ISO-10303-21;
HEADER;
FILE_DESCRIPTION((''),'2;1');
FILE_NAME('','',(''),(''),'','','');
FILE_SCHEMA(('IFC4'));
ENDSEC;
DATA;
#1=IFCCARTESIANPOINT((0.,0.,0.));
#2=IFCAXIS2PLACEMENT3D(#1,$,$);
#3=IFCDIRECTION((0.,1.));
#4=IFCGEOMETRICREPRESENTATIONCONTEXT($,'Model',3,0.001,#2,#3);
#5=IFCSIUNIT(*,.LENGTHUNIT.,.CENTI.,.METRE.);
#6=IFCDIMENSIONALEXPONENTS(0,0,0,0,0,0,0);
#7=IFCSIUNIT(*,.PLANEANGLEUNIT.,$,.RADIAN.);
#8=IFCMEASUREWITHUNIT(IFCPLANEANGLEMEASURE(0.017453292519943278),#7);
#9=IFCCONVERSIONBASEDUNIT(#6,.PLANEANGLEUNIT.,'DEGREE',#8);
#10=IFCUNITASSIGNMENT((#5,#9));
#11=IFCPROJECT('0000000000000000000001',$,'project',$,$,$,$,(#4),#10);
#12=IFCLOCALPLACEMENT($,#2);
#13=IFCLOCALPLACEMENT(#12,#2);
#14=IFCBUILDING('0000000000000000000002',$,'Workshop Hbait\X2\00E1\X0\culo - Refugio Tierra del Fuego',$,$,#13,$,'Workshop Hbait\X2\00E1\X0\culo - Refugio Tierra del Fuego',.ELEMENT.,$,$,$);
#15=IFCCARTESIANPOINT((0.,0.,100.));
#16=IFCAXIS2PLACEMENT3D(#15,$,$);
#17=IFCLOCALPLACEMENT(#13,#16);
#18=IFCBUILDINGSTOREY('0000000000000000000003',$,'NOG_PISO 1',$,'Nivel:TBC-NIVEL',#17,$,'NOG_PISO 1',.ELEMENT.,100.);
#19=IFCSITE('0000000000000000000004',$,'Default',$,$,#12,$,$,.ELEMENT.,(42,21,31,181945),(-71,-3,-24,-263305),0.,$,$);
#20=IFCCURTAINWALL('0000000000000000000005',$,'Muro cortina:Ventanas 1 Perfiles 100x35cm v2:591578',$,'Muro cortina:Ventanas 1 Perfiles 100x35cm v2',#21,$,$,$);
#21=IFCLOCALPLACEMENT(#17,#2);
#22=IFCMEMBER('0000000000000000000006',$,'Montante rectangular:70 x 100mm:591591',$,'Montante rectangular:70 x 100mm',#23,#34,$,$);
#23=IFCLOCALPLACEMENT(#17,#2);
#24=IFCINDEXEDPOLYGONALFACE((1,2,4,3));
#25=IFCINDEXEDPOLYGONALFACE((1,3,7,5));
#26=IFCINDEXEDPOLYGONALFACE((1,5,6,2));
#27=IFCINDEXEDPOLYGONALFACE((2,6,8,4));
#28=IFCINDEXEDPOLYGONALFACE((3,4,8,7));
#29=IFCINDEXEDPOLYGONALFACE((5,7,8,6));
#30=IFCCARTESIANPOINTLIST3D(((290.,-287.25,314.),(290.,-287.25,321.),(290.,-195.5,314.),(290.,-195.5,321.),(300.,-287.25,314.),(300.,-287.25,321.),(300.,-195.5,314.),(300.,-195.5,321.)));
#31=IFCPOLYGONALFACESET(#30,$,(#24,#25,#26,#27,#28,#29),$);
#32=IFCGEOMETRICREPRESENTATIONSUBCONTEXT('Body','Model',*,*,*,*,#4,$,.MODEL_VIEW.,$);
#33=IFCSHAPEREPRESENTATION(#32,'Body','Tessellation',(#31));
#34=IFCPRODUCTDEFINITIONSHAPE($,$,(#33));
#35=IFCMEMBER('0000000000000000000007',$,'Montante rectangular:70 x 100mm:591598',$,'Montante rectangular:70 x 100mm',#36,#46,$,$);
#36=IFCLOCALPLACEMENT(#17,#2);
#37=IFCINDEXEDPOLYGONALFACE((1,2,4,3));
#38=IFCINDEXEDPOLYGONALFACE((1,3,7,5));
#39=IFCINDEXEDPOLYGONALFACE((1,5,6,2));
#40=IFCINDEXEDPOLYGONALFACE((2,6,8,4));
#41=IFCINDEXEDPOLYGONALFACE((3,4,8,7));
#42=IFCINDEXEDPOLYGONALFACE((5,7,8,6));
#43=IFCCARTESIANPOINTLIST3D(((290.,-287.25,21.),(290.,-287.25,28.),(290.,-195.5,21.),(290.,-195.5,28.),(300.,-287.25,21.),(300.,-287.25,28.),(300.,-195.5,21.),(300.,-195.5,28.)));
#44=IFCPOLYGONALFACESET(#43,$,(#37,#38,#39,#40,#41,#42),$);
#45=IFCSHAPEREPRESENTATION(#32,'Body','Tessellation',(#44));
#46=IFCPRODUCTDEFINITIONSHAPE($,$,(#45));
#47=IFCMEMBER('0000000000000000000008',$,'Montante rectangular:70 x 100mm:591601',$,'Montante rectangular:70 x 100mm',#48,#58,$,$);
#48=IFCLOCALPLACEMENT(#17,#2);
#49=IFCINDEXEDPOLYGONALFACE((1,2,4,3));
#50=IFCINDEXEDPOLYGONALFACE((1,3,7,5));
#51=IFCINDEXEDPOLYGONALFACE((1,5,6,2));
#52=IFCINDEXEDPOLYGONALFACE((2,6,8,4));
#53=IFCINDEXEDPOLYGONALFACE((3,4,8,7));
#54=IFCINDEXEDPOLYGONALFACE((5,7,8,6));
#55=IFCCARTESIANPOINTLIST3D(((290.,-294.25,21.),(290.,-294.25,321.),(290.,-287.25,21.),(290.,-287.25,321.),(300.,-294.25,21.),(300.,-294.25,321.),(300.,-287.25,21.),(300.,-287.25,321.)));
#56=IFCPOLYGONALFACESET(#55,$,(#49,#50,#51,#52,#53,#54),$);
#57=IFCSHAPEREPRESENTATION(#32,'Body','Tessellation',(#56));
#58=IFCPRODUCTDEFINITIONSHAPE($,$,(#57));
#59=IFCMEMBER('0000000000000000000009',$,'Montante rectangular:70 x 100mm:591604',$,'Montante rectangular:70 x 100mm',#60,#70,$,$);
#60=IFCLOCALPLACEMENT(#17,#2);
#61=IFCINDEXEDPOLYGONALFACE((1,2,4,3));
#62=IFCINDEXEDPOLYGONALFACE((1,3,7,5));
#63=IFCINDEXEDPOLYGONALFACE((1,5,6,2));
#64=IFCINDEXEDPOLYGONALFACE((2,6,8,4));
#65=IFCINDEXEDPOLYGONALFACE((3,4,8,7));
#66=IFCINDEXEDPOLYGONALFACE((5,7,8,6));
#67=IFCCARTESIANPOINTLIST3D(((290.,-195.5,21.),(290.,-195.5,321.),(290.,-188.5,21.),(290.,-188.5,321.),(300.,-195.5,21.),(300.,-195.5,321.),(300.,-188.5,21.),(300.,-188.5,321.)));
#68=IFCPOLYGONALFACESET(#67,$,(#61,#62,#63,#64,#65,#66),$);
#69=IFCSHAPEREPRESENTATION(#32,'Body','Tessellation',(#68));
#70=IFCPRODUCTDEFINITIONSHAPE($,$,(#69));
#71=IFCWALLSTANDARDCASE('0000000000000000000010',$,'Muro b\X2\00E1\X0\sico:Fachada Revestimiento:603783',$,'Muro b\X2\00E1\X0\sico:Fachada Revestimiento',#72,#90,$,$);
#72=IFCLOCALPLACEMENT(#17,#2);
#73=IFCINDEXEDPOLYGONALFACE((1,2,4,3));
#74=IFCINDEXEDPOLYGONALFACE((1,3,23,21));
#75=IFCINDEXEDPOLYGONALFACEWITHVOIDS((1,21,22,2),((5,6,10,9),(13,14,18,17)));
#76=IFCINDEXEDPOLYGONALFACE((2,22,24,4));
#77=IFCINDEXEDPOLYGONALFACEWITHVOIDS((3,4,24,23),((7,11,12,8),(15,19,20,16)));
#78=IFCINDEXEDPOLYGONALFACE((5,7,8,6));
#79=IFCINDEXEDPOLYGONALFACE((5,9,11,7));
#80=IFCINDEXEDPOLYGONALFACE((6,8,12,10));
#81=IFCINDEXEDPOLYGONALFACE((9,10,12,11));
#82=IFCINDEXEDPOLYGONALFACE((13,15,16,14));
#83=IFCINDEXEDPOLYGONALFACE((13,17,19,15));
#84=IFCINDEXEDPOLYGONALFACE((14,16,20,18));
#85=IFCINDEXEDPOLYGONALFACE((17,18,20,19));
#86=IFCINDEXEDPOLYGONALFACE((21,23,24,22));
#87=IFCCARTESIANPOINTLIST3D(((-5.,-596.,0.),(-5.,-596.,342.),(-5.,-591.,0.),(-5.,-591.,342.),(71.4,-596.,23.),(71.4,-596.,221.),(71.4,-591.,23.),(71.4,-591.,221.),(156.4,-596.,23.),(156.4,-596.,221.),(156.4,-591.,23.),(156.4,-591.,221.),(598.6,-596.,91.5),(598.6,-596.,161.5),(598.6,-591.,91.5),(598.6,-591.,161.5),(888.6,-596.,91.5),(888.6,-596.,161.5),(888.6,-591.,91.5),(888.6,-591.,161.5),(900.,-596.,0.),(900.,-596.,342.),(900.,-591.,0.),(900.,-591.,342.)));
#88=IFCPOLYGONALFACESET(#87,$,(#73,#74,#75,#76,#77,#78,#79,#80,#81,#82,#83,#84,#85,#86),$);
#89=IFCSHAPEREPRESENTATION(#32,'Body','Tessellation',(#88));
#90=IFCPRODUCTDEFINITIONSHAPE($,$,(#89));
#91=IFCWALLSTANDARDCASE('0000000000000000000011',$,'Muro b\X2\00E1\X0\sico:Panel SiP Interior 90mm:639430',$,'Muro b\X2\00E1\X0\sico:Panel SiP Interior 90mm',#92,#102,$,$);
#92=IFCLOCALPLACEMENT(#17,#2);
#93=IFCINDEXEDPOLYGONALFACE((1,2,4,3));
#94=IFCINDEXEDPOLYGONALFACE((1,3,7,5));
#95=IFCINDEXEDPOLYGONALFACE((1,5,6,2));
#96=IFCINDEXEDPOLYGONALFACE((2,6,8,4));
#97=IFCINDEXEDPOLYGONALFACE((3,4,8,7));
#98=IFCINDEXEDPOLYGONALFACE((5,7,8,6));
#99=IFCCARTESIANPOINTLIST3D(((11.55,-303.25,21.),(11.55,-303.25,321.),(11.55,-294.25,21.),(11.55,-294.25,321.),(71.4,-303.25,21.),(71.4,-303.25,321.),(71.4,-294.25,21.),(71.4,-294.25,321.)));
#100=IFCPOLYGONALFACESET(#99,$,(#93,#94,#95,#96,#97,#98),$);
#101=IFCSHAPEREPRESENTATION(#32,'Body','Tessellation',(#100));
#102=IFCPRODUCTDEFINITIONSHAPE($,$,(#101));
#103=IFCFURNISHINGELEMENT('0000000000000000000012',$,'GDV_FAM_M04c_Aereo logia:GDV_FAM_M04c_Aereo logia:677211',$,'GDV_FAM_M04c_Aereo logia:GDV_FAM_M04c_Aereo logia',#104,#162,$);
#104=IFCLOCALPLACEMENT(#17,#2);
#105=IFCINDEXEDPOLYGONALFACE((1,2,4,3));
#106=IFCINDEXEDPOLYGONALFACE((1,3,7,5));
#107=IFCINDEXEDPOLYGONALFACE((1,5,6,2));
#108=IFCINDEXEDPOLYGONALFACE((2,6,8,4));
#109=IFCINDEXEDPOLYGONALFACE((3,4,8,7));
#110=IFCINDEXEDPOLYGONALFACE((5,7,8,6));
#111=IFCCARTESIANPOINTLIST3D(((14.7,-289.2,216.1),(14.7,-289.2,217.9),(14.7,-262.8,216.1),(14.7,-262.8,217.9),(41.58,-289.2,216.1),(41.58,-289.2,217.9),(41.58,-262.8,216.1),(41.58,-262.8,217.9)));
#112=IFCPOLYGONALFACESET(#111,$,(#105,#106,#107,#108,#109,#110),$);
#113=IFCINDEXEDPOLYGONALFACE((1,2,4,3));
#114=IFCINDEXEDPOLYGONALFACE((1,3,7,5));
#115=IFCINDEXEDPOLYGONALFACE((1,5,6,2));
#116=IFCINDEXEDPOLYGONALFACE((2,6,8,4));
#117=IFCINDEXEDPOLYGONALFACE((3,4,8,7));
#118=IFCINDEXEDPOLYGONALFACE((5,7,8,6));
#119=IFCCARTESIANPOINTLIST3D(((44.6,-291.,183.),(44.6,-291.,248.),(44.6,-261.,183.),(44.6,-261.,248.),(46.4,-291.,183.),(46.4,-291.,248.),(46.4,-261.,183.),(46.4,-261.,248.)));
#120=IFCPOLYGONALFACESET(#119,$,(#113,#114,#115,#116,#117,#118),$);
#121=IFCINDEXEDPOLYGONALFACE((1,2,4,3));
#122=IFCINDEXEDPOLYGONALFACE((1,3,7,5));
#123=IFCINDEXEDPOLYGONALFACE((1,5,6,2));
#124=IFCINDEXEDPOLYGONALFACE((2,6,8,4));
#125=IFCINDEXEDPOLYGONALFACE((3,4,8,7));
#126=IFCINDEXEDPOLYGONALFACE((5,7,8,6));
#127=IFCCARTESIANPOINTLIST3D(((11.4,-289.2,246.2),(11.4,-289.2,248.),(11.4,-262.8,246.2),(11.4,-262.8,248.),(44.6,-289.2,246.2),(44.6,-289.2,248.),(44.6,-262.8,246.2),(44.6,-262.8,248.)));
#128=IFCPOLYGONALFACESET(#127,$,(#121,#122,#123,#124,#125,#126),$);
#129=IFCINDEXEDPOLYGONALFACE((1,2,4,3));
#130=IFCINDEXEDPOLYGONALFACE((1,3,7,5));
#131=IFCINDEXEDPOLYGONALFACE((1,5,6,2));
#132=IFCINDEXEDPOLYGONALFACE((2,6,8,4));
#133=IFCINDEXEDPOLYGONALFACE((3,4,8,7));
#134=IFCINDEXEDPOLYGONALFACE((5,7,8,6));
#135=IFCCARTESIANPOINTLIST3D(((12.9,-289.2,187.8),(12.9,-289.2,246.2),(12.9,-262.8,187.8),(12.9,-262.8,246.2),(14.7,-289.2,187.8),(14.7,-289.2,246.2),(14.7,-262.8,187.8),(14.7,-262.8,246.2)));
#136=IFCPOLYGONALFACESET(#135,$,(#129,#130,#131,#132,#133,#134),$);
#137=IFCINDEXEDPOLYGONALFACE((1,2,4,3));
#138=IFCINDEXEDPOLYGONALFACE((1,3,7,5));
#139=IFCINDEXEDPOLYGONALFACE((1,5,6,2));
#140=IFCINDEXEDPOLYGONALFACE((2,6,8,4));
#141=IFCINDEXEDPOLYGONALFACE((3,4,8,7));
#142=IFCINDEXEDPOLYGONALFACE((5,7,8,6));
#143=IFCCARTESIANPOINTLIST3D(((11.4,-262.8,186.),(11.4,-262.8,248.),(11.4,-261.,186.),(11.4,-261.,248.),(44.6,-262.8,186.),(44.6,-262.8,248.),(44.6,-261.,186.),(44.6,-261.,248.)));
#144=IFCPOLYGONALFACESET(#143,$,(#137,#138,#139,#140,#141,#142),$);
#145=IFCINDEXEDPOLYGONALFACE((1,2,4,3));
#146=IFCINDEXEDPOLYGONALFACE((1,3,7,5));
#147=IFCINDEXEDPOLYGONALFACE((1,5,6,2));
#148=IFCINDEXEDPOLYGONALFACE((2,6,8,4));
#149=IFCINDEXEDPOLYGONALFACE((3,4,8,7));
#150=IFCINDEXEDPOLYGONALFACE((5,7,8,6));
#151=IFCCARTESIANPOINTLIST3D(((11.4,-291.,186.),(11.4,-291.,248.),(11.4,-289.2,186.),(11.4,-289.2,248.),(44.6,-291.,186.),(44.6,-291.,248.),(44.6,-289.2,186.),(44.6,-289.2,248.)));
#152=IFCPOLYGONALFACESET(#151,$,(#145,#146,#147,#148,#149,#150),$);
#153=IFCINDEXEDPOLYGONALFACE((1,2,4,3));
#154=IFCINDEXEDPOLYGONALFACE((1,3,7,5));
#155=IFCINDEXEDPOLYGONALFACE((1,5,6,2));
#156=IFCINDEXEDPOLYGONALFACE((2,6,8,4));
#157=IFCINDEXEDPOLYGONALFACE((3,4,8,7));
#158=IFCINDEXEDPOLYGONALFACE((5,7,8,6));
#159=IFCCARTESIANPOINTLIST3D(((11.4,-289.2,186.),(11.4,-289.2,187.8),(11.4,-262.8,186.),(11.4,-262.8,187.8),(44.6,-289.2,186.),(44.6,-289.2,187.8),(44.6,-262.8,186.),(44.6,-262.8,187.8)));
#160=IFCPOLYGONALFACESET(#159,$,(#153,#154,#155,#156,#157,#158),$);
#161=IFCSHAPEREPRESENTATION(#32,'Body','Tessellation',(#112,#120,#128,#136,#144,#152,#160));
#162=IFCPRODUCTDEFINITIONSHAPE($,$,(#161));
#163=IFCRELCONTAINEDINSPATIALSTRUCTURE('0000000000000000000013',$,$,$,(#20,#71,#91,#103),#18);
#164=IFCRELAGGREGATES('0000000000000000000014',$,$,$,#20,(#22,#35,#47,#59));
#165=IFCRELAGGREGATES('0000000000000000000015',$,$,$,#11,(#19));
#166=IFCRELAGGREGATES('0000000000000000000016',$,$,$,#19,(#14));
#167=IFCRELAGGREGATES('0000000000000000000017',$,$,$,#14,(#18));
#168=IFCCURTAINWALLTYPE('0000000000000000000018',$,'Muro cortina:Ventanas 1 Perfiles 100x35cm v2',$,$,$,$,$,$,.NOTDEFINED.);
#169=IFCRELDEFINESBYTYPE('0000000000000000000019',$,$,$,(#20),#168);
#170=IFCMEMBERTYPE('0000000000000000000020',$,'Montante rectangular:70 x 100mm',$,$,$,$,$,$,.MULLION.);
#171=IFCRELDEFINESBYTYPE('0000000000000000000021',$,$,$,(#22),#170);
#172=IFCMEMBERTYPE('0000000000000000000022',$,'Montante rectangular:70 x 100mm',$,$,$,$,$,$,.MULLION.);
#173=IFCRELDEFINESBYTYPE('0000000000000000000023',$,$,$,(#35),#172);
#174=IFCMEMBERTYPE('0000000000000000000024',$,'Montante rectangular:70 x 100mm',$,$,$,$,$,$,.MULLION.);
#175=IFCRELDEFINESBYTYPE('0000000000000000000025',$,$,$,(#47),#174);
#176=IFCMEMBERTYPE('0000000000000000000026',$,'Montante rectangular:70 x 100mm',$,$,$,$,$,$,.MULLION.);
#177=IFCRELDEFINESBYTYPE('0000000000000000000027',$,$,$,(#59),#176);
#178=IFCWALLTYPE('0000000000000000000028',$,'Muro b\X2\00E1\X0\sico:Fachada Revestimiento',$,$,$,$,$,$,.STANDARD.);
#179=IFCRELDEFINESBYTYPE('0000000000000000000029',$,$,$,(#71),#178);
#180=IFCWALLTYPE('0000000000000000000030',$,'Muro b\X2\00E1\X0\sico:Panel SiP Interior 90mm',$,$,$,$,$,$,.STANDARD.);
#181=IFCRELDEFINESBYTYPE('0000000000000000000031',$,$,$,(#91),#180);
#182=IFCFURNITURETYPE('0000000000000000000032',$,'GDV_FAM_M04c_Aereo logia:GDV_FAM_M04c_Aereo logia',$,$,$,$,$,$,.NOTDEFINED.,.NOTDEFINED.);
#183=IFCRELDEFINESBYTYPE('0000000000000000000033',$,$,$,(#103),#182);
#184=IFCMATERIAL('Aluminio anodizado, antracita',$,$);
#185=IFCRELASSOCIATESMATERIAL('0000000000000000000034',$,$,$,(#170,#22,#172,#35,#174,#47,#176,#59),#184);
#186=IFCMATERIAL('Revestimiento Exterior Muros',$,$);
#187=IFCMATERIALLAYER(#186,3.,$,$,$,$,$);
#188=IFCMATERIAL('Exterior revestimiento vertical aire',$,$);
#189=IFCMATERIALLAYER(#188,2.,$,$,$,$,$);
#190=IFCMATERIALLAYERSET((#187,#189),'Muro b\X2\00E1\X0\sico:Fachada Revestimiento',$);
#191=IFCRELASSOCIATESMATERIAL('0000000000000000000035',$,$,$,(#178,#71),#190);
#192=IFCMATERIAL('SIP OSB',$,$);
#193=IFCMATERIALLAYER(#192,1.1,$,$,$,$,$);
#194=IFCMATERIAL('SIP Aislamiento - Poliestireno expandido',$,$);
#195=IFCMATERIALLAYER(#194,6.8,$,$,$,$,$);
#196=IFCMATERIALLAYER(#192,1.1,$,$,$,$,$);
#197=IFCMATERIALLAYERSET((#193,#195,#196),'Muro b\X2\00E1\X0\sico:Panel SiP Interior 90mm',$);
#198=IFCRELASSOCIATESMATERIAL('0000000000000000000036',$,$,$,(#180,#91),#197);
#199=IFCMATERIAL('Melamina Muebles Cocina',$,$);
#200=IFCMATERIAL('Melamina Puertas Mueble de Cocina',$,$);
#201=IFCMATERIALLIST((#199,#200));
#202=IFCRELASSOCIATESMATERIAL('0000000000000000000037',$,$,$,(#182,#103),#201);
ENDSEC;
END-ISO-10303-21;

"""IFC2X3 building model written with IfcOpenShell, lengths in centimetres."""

from ifc_helpers import new_model, entity, si_unit, converted_unit, direction, frame, frame_2d, origin, origin_2d_with_axis, place, context, subcontext, project, spatial, rectangle, extrude, source, transform, mapped, material, material_list, layer, layer_set, layer_usage, type_object, type_shapes, element, aggregate, save


model = new_model("IFC2X3")

# Units and contexts
model_context = context("Model", 3, precision=0.001, world=origin(), true_north=direction((0.0, 1.0)))
body_context = subcontext(model_context, "Body", "Model", "MODEL_VIEW")
ifc_project = project(units=[si_unit("LENGTHUNIT", "METRE", prefix="CENTI"), converted_unit("PLANEANGLEUNIT", "DEGREE", entity("IfcPlaneAngleMeasure", 0.017453292519943278), si_unit("PLANEANGLEUNIT", "RADIAN"), dimensions=[0, 0, 0, 0, 0, 0, 0])], contexts=[model_context])

# Site, building, storey
site_placement = place(None, origin())
site = spatial("IfcSite", under=ifc_project, at=site_placement, Name="Default", CompositionType="ELEMENT", RefLatitude=(42, 21, 31, 181945), RefLongitude=(-71, -3, -24, -263305), RefElevation=0.0)
building_placement = place(site_placement, origin())
building = spatial("IfcBuilding", under=site, at=building_placement, Name="Workshop Hbaitáculo - Refugio Tierra del Fuego", LongName="Workshop Hbaitáculo - Refugio Tierra del Fuego", CompositionType="ELEMENT")
storey_placement = place(building_placement, frame((0.0, 0.0, 100.0)))
storey = spatial("IfcBuildingStorey", under=building, at=storey_placement, Name="NOG_PISO 1", ObjectType="Nivel:TBC-NIVEL", LongName="NOG_PISO 1", CompositionType="ELEMENT", Elevation=100.0)

# Curtain wall, members
curtain_wall_type = type_object("IfcCurtainWallType", Name="Muro cortina:Ventanas 1 Perfiles 100x35cm v2", PredefinedType="NOTDEFINED")
curtain_wall_placement = place(storey_placement, frame((0.0, 0.0, -100.0)))
curtain_wall = element("IfcCurtainWall", 1, at=curtain_wall_placement, inside=storey, type_object=curtain_wall_type, Name="Muro cortina:Ventanas 1 Perfiles 100x35cm v2:591578", ObjectType="Muro cortina:Ventanas 1 Perfiles 100x35cm v2")
ifc_material_1 = material(Name="Aluminio anodizado, antracita")
member_type_1 = type_object("IfcMemberType", Name="Montante rectangular:70 x 100mm", PredefinedType="MULLION", material=ifc_material_1)
shared_shape_1 = source(origin(), body_context, "Body", "SweptSolid", [
    extrude(rectangle(XDim=7.0, YDim=10.0, at=origin_2d_with_axis()), frame((-3.5, 0.0, -91.75), z_axis=(0.0, 0.0, 1.0), x_axis=(-1.0, 0.0, 0.0)), (0.0, 0.0, 1.0), 91.75),
])
type_shapes(member_type_1, [shared_shape_1])
member_1_placement = place(curtain_wall_placement, frame((295.0, -287.25, 421.0), z_axis=(0.0, -1.0, 0.0), x_axis=(0.0, 0.0, 1.0)))
member_1 = element("IfcMember", 2, at=member_1_placement, type_object=member_type_1, material=ifc_material_1, Name="Montante rectangular:70 x 100mm:591591", ObjectType="Montante rectangular:70 x 100mm", context=body_context, shape_type="MappedRepresentation", body=[
    mapped(shared_shape_1, transform((0.0, 0.0, 0.0), scale=1.0)),
])
member_type_2 = type_object("IfcMemberType", Name="Montante rectangular:70 x 100mm", PredefinedType="MULLION", material=ifc_material_1)
shared_shape_2 = source(origin(), body_context, "Body", "SweptSolid", [
    extrude(rectangle(XDim=7.0, YDim=10.0, at=origin_2d_with_axis()), frame((-3.5, 0.0, -91.75), z_axis=(0.0, 0.0, 1.0), x_axis=(-1.0, 0.0, 0.0)), (0.0, 0.0, 1.0), 91.75),
])
type_shapes(member_type_2, [shared_shape_2])
member_2_placement = place(curtain_wall_placement, frame((295.0, -195.5, 121.0), z_axis=(0.0, 1.0, 0.0), x_axis=(0.0, 0.0, -1.0)))
member_2 = element("IfcMember", 3, at=member_2_placement, type_object=member_type_2, material=ifc_material_1, Name="Montante rectangular:70 x 100mm:591598", ObjectType="Montante rectangular:70 x 100mm", context=body_context, shape_type="MappedRepresentation", body=[
    mapped(shared_shape_2, transform((0.0, 0.0, 0.0), scale=1.0)),
])
member_type_3 = type_object("IfcMemberType", Name="Montante rectangular:70 x 100mm", PredefinedType="MULLION", material=ifc_material_1)
shared_shape_3 = source(origin(), body_context, "Body", "SweptSolid", [
    extrude(rectangle(XDim=7.0, YDim=10.0, at=origin_2d_with_axis()), frame((-3.5, 0.0, -300.0), z_axis=(0.0, 0.0, 1.0), x_axis=(-1.0, 0.0, 0.0)), (0.0, 0.0, 1.0), 300.0),
])
type_shapes(member_type_3, [shared_shape_3])
member_3_placement = place(curtain_wall_placement, frame((295.0, -294.25, 121.0), z_axis=(0.0, 0.0, -1.0), x_axis=(0.0, -1.0, 0.0)))
member_3 = element("IfcMember", 4, at=member_3_placement, type_object=member_type_3, material=ifc_material_1, Name="Montante rectangular:70 x 100mm:591601", ObjectType="Montante rectangular:70 x 100mm", context=body_context, shape_type="MappedRepresentation", body=[
    mapped(shared_shape_3, transform((0.0, 0.0, 0.0), scale=1.0)),
])
member_type_4 = type_object("IfcMemberType", Name="Montante rectangular:70 x 100mm", PredefinedType="MULLION", material=ifc_material_1)
shared_shape_4 = source(origin(), body_context, "Body", "SweptSolid", [
    extrude(rectangle(XDim=7.0, YDim=10.0, at=frame_2d((0.0, 0.0), x_axis=(1.0, 0.0))), frame((0.0, 0.0, -300.0), z_axis=(0.0, 0.0, 1.0), x_axis=(-1.0, 0.0, 0.0)), (0.0, 0.0, 1.0), 300.0),
])
type_shapes(member_type_4, [shared_shape_4])
member_4_placement = place(curtain_wall_placement, frame((295.0, -192.0, 121.0), z_axis=(0.0, 0.0, -1.0), x_axis=(0.0, -1.0, 0.0)))
member_4 = element("IfcMember", 5, at=member_4_placement, type_object=member_type_4, material=ifc_material_1, Name="Montante rectangular:70 x 100mm:591604", ObjectType="Montante rectangular:70 x 100mm", context=body_context, shape_type="MappedRepresentation", body=[
    mapped(shared_shape_4, transform((0.0, 0.0, 0.0), scale=1.0)),
])
aggregate(curtain_wall, [member_1, member_2, member_3, member_4])

# Wall, openings
ifc_material_2 = material(Name="Revestimiento Exterior Muros")
ifc_layer_1 = layer(ifc_material_2, 3.0)
ifc_material_3 = material(Name="Exterior revestimiento vertical aire")
ifc_layer_2 = layer(ifc_material_3, 2.0)
ifc_layer_set_1 = layer_set([ifc_layer_1, ifc_layer_2], Name="Muro básico:Fachada Revestimiento")
ifc_layer_usage_1 = layer_usage(ifc_layer_set_1, "AXIS2", "POSITIVE", -2.5)
wall_type_1 = type_object("IfcWallType", Name="Muro básico:Fachada Revestimiento", PredefinedType="STANDARD", material=ifc_layer_set_1)
wall_1_placement = place(storey_placement, frame((-5.0, -593.5, 0.0)))
wall_1 = element("IfcWallStandardCase", 6, at=wall_1_placement, inside=storey, type_object=wall_type_1, material=ifc_layer_usage_1, Name="Muro básico:Fachada Revestimiento:603783", ObjectType="Muro básico:Fachada Revestimiento", context=body_context, shape_type="SweptSolid", body=[
    extrude(rectangle(XDim=905.0, YDim=5.0, at=frame_2d((452.5, 0.0), x_axis=(-1.0, 0.0))), origin(), (0.0, 0.0, 1.0), 342.0),
])
opening_1_placement = place(wall_1_placement, origin())
element("IfcOpeningElement", 7, at=opening_1_placement, cuts=wall_1, ObjectType="Opening", context=body_context, shape_type="SweptSolid", body=[
    extrude(rectangle(XDim=198.0, YDim=85.0, at=frame_2d((0.0, 0.0), x_axis=(1.0, 0.0))), frame((118.9, 2.5, 122.0), z_axis=(0.0, -1.0, 0.0), x_axis=(0.0, 0.0, 1.0)), (0.0, 0.0, 1.0), 5.0),
])
opening_2_placement = place(wall_1_placement, origin())
element("IfcOpeningElement", 8, at=opening_2_placement, cuts=wall_1, ObjectType="Opening", context=body_context, shape_type="SweptSolid", body=[
    extrude(rectangle(XDim=70.0, YDim=290.0, at=frame_2d((0.0, 0.0), x_axis=(1.0, 0.0))), frame((748.6, 2.5, 126.5), z_axis=(0.0, -1.0, 0.0), x_axis=(0.0, 0.0, -1.0)), (0.0, 0.0, 1.0), 5.0),
])

# Wall
ifc_material_4 = material(Name="SIP OSB")
ifc_layer_3 = layer(ifc_material_4, 1.1)
ifc_material_5 = material(Name="SIP Aislamiento - Poliestireno expandido")
ifc_layer_4 = layer(ifc_material_5, 6.8)
ifc_layer_5 = layer(ifc_material_4, 1.1)
ifc_layer_set_2 = layer_set([ifc_layer_3, ifc_layer_4, ifc_layer_5], Name="Muro básico:Panel SiP Interior 90mm")
ifc_layer_usage_2 = layer_usage(ifc_layer_set_2, "AXIS2", "NEGATIVE", 4.5)
wall_type_2 = type_object("IfcWallType", Name="Muro básico:Panel SiP Interior 90mm", PredefinedType="STANDARD", material=ifc_layer_set_2)
wall_2_placement = place(storey_placement, frame((71.4, -298.75, 21.0), z_axis=(0.0, 0.0, 1.0), x_axis=(-1.0, 0.0, 0.0)))
element("IfcWallStandardCase", 9, at=wall_2_placement, inside=storey, type_object=wall_type_2, material=ifc_layer_usage_2, Name="Muro básico:Panel SiP Interior 90mm:639430", ObjectType="Muro básico:Panel SiP Interior 90mm", context=body_context, shape_type="SweptSolid", body=[
    extrude(rectangle(XDim=59.85, YDim=9.0, at=frame_2d((29.93, 0.0), x_axis=(-1.0, 0.0))), origin(), (0.0, 0.0, 1.0), 300.0),
])

# Furnishing element
ifc_material_6 = material(Name="Melamina Muebles Cocina")
ifc_material_7 = material(Name="Melamina Puertas Mueble de Cocina")
ifc_material_list = material_list([ifc_material_6, ifc_material_7])
furniture_type = type_object("IfcFurnitureType", Name="GDV_FAM_M04c_Aereo logia:GDV_FAM_M04c_Aereo logia", AssemblyPlace="NOTDEFINED", material=ifc_material_list)
shared_shape_5 = source(origin(), body_context, "Body", "SweptSolid", [
    extrude(rectangle(XDim=26.4, YDim=26.88, at=frame_2d((0.0, 0.0), x_axis=(1.0, 0.0))), frame((15.0, -16.74, 33.1), z_axis=(0.0, 0.0, 1.0), x_axis=(-1.0, 0.0, 0.0)), (0.0, 0.0, 1.0), 1.8),
    extrude(rectangle(XDim=30.0, YDim=1.8, at=frame_2d((0.0, 0.0), x_axis=(1.0, 0.0))), frame((15.0, -34.1, 0.0), z_axis=(0.0, 0.0, 1.0), x_axis=(-1.0, 0.0, 0.0)), (0.0, 0.0, 1.0), 65.0),
    extrude(rectangle(XDim=26.4, YDim=33.2, at=origin_2d_with_axis()), frame((15.0, -16.6, 63.2), z_axis=(0.0, 0.0, 1.0), x_axis=(-1.0, 0.0, 0.0)), (0.0, 0.0, 1.0), 1.8),
    extrude(rectangle(XDim=26.4, YDim=1.8, at=origin_2d_with_axis()), frame((15.0, -2.4, 4.8), z_axis=(0.0, 0.0, 1.0), x_axis=(-1.0, 0.0, 0.0)), (0.0, 0.0, 1.0), 58.4),
    extrude(rectangle(XDim=33.2, YDim=1.8, at=origin_2d_with_axis()), frame((29.1, -16.6, 3.0), z_axis=(0.0, 0.0, 1.0), x_axis=(0.0, 1.0, 0.0)), (0.0, 0.0, 1.0), 62.0),
    extrude(rectangle(XDim=33.2, YDim=1.8, at=origin_2d_with_axis()), frame((0.9, -16.6, 3.0), z_axis=(0.0, 0.0, 1.0), x_axis=(0.0, 1.0, 0.0)), (0.0, 0.0, 1.0), 62.0),
    extrude(rectangle(XDim=26.4, YDim=33.2, at=origin_2d_with_axis()), frame((15.0, -16.6, 3.0), z_axis=(0.0, 0.0, 1.0), x_axis=(-1.0, 0.0, 0.0)), (0.0, 0.0, 1.0), 1.8),
])
type_shapes(furniture_type, [shared_shape_5])
furnishing_placement = place(storey_placement, frame((11.4, -291.0, 183.0), z_axis=(0.0, 0.0, 1.0), x_axis=(0.0, 1.0, 0.0)))
element("IfcFurnishingElement", 10, at=furnishing_placement, inside=storey, type_object=furniture_type, material=ifc_material_list, Name="GDV_FAM_M04c_Aereo logia:GDV_FAM_M04c_Aereo logia:677211", ObjectType="GDV_FAM_M04c_Aereo logia:GDV_FAM_M04c_Aereo logia", context=body_context, shape_type="MappedRepresentation", body=[
    mapped(shared_shape_5, transform((0.0, 0.0, 0.0), scale=1.0)),
])

save(model, "model.ifc")
